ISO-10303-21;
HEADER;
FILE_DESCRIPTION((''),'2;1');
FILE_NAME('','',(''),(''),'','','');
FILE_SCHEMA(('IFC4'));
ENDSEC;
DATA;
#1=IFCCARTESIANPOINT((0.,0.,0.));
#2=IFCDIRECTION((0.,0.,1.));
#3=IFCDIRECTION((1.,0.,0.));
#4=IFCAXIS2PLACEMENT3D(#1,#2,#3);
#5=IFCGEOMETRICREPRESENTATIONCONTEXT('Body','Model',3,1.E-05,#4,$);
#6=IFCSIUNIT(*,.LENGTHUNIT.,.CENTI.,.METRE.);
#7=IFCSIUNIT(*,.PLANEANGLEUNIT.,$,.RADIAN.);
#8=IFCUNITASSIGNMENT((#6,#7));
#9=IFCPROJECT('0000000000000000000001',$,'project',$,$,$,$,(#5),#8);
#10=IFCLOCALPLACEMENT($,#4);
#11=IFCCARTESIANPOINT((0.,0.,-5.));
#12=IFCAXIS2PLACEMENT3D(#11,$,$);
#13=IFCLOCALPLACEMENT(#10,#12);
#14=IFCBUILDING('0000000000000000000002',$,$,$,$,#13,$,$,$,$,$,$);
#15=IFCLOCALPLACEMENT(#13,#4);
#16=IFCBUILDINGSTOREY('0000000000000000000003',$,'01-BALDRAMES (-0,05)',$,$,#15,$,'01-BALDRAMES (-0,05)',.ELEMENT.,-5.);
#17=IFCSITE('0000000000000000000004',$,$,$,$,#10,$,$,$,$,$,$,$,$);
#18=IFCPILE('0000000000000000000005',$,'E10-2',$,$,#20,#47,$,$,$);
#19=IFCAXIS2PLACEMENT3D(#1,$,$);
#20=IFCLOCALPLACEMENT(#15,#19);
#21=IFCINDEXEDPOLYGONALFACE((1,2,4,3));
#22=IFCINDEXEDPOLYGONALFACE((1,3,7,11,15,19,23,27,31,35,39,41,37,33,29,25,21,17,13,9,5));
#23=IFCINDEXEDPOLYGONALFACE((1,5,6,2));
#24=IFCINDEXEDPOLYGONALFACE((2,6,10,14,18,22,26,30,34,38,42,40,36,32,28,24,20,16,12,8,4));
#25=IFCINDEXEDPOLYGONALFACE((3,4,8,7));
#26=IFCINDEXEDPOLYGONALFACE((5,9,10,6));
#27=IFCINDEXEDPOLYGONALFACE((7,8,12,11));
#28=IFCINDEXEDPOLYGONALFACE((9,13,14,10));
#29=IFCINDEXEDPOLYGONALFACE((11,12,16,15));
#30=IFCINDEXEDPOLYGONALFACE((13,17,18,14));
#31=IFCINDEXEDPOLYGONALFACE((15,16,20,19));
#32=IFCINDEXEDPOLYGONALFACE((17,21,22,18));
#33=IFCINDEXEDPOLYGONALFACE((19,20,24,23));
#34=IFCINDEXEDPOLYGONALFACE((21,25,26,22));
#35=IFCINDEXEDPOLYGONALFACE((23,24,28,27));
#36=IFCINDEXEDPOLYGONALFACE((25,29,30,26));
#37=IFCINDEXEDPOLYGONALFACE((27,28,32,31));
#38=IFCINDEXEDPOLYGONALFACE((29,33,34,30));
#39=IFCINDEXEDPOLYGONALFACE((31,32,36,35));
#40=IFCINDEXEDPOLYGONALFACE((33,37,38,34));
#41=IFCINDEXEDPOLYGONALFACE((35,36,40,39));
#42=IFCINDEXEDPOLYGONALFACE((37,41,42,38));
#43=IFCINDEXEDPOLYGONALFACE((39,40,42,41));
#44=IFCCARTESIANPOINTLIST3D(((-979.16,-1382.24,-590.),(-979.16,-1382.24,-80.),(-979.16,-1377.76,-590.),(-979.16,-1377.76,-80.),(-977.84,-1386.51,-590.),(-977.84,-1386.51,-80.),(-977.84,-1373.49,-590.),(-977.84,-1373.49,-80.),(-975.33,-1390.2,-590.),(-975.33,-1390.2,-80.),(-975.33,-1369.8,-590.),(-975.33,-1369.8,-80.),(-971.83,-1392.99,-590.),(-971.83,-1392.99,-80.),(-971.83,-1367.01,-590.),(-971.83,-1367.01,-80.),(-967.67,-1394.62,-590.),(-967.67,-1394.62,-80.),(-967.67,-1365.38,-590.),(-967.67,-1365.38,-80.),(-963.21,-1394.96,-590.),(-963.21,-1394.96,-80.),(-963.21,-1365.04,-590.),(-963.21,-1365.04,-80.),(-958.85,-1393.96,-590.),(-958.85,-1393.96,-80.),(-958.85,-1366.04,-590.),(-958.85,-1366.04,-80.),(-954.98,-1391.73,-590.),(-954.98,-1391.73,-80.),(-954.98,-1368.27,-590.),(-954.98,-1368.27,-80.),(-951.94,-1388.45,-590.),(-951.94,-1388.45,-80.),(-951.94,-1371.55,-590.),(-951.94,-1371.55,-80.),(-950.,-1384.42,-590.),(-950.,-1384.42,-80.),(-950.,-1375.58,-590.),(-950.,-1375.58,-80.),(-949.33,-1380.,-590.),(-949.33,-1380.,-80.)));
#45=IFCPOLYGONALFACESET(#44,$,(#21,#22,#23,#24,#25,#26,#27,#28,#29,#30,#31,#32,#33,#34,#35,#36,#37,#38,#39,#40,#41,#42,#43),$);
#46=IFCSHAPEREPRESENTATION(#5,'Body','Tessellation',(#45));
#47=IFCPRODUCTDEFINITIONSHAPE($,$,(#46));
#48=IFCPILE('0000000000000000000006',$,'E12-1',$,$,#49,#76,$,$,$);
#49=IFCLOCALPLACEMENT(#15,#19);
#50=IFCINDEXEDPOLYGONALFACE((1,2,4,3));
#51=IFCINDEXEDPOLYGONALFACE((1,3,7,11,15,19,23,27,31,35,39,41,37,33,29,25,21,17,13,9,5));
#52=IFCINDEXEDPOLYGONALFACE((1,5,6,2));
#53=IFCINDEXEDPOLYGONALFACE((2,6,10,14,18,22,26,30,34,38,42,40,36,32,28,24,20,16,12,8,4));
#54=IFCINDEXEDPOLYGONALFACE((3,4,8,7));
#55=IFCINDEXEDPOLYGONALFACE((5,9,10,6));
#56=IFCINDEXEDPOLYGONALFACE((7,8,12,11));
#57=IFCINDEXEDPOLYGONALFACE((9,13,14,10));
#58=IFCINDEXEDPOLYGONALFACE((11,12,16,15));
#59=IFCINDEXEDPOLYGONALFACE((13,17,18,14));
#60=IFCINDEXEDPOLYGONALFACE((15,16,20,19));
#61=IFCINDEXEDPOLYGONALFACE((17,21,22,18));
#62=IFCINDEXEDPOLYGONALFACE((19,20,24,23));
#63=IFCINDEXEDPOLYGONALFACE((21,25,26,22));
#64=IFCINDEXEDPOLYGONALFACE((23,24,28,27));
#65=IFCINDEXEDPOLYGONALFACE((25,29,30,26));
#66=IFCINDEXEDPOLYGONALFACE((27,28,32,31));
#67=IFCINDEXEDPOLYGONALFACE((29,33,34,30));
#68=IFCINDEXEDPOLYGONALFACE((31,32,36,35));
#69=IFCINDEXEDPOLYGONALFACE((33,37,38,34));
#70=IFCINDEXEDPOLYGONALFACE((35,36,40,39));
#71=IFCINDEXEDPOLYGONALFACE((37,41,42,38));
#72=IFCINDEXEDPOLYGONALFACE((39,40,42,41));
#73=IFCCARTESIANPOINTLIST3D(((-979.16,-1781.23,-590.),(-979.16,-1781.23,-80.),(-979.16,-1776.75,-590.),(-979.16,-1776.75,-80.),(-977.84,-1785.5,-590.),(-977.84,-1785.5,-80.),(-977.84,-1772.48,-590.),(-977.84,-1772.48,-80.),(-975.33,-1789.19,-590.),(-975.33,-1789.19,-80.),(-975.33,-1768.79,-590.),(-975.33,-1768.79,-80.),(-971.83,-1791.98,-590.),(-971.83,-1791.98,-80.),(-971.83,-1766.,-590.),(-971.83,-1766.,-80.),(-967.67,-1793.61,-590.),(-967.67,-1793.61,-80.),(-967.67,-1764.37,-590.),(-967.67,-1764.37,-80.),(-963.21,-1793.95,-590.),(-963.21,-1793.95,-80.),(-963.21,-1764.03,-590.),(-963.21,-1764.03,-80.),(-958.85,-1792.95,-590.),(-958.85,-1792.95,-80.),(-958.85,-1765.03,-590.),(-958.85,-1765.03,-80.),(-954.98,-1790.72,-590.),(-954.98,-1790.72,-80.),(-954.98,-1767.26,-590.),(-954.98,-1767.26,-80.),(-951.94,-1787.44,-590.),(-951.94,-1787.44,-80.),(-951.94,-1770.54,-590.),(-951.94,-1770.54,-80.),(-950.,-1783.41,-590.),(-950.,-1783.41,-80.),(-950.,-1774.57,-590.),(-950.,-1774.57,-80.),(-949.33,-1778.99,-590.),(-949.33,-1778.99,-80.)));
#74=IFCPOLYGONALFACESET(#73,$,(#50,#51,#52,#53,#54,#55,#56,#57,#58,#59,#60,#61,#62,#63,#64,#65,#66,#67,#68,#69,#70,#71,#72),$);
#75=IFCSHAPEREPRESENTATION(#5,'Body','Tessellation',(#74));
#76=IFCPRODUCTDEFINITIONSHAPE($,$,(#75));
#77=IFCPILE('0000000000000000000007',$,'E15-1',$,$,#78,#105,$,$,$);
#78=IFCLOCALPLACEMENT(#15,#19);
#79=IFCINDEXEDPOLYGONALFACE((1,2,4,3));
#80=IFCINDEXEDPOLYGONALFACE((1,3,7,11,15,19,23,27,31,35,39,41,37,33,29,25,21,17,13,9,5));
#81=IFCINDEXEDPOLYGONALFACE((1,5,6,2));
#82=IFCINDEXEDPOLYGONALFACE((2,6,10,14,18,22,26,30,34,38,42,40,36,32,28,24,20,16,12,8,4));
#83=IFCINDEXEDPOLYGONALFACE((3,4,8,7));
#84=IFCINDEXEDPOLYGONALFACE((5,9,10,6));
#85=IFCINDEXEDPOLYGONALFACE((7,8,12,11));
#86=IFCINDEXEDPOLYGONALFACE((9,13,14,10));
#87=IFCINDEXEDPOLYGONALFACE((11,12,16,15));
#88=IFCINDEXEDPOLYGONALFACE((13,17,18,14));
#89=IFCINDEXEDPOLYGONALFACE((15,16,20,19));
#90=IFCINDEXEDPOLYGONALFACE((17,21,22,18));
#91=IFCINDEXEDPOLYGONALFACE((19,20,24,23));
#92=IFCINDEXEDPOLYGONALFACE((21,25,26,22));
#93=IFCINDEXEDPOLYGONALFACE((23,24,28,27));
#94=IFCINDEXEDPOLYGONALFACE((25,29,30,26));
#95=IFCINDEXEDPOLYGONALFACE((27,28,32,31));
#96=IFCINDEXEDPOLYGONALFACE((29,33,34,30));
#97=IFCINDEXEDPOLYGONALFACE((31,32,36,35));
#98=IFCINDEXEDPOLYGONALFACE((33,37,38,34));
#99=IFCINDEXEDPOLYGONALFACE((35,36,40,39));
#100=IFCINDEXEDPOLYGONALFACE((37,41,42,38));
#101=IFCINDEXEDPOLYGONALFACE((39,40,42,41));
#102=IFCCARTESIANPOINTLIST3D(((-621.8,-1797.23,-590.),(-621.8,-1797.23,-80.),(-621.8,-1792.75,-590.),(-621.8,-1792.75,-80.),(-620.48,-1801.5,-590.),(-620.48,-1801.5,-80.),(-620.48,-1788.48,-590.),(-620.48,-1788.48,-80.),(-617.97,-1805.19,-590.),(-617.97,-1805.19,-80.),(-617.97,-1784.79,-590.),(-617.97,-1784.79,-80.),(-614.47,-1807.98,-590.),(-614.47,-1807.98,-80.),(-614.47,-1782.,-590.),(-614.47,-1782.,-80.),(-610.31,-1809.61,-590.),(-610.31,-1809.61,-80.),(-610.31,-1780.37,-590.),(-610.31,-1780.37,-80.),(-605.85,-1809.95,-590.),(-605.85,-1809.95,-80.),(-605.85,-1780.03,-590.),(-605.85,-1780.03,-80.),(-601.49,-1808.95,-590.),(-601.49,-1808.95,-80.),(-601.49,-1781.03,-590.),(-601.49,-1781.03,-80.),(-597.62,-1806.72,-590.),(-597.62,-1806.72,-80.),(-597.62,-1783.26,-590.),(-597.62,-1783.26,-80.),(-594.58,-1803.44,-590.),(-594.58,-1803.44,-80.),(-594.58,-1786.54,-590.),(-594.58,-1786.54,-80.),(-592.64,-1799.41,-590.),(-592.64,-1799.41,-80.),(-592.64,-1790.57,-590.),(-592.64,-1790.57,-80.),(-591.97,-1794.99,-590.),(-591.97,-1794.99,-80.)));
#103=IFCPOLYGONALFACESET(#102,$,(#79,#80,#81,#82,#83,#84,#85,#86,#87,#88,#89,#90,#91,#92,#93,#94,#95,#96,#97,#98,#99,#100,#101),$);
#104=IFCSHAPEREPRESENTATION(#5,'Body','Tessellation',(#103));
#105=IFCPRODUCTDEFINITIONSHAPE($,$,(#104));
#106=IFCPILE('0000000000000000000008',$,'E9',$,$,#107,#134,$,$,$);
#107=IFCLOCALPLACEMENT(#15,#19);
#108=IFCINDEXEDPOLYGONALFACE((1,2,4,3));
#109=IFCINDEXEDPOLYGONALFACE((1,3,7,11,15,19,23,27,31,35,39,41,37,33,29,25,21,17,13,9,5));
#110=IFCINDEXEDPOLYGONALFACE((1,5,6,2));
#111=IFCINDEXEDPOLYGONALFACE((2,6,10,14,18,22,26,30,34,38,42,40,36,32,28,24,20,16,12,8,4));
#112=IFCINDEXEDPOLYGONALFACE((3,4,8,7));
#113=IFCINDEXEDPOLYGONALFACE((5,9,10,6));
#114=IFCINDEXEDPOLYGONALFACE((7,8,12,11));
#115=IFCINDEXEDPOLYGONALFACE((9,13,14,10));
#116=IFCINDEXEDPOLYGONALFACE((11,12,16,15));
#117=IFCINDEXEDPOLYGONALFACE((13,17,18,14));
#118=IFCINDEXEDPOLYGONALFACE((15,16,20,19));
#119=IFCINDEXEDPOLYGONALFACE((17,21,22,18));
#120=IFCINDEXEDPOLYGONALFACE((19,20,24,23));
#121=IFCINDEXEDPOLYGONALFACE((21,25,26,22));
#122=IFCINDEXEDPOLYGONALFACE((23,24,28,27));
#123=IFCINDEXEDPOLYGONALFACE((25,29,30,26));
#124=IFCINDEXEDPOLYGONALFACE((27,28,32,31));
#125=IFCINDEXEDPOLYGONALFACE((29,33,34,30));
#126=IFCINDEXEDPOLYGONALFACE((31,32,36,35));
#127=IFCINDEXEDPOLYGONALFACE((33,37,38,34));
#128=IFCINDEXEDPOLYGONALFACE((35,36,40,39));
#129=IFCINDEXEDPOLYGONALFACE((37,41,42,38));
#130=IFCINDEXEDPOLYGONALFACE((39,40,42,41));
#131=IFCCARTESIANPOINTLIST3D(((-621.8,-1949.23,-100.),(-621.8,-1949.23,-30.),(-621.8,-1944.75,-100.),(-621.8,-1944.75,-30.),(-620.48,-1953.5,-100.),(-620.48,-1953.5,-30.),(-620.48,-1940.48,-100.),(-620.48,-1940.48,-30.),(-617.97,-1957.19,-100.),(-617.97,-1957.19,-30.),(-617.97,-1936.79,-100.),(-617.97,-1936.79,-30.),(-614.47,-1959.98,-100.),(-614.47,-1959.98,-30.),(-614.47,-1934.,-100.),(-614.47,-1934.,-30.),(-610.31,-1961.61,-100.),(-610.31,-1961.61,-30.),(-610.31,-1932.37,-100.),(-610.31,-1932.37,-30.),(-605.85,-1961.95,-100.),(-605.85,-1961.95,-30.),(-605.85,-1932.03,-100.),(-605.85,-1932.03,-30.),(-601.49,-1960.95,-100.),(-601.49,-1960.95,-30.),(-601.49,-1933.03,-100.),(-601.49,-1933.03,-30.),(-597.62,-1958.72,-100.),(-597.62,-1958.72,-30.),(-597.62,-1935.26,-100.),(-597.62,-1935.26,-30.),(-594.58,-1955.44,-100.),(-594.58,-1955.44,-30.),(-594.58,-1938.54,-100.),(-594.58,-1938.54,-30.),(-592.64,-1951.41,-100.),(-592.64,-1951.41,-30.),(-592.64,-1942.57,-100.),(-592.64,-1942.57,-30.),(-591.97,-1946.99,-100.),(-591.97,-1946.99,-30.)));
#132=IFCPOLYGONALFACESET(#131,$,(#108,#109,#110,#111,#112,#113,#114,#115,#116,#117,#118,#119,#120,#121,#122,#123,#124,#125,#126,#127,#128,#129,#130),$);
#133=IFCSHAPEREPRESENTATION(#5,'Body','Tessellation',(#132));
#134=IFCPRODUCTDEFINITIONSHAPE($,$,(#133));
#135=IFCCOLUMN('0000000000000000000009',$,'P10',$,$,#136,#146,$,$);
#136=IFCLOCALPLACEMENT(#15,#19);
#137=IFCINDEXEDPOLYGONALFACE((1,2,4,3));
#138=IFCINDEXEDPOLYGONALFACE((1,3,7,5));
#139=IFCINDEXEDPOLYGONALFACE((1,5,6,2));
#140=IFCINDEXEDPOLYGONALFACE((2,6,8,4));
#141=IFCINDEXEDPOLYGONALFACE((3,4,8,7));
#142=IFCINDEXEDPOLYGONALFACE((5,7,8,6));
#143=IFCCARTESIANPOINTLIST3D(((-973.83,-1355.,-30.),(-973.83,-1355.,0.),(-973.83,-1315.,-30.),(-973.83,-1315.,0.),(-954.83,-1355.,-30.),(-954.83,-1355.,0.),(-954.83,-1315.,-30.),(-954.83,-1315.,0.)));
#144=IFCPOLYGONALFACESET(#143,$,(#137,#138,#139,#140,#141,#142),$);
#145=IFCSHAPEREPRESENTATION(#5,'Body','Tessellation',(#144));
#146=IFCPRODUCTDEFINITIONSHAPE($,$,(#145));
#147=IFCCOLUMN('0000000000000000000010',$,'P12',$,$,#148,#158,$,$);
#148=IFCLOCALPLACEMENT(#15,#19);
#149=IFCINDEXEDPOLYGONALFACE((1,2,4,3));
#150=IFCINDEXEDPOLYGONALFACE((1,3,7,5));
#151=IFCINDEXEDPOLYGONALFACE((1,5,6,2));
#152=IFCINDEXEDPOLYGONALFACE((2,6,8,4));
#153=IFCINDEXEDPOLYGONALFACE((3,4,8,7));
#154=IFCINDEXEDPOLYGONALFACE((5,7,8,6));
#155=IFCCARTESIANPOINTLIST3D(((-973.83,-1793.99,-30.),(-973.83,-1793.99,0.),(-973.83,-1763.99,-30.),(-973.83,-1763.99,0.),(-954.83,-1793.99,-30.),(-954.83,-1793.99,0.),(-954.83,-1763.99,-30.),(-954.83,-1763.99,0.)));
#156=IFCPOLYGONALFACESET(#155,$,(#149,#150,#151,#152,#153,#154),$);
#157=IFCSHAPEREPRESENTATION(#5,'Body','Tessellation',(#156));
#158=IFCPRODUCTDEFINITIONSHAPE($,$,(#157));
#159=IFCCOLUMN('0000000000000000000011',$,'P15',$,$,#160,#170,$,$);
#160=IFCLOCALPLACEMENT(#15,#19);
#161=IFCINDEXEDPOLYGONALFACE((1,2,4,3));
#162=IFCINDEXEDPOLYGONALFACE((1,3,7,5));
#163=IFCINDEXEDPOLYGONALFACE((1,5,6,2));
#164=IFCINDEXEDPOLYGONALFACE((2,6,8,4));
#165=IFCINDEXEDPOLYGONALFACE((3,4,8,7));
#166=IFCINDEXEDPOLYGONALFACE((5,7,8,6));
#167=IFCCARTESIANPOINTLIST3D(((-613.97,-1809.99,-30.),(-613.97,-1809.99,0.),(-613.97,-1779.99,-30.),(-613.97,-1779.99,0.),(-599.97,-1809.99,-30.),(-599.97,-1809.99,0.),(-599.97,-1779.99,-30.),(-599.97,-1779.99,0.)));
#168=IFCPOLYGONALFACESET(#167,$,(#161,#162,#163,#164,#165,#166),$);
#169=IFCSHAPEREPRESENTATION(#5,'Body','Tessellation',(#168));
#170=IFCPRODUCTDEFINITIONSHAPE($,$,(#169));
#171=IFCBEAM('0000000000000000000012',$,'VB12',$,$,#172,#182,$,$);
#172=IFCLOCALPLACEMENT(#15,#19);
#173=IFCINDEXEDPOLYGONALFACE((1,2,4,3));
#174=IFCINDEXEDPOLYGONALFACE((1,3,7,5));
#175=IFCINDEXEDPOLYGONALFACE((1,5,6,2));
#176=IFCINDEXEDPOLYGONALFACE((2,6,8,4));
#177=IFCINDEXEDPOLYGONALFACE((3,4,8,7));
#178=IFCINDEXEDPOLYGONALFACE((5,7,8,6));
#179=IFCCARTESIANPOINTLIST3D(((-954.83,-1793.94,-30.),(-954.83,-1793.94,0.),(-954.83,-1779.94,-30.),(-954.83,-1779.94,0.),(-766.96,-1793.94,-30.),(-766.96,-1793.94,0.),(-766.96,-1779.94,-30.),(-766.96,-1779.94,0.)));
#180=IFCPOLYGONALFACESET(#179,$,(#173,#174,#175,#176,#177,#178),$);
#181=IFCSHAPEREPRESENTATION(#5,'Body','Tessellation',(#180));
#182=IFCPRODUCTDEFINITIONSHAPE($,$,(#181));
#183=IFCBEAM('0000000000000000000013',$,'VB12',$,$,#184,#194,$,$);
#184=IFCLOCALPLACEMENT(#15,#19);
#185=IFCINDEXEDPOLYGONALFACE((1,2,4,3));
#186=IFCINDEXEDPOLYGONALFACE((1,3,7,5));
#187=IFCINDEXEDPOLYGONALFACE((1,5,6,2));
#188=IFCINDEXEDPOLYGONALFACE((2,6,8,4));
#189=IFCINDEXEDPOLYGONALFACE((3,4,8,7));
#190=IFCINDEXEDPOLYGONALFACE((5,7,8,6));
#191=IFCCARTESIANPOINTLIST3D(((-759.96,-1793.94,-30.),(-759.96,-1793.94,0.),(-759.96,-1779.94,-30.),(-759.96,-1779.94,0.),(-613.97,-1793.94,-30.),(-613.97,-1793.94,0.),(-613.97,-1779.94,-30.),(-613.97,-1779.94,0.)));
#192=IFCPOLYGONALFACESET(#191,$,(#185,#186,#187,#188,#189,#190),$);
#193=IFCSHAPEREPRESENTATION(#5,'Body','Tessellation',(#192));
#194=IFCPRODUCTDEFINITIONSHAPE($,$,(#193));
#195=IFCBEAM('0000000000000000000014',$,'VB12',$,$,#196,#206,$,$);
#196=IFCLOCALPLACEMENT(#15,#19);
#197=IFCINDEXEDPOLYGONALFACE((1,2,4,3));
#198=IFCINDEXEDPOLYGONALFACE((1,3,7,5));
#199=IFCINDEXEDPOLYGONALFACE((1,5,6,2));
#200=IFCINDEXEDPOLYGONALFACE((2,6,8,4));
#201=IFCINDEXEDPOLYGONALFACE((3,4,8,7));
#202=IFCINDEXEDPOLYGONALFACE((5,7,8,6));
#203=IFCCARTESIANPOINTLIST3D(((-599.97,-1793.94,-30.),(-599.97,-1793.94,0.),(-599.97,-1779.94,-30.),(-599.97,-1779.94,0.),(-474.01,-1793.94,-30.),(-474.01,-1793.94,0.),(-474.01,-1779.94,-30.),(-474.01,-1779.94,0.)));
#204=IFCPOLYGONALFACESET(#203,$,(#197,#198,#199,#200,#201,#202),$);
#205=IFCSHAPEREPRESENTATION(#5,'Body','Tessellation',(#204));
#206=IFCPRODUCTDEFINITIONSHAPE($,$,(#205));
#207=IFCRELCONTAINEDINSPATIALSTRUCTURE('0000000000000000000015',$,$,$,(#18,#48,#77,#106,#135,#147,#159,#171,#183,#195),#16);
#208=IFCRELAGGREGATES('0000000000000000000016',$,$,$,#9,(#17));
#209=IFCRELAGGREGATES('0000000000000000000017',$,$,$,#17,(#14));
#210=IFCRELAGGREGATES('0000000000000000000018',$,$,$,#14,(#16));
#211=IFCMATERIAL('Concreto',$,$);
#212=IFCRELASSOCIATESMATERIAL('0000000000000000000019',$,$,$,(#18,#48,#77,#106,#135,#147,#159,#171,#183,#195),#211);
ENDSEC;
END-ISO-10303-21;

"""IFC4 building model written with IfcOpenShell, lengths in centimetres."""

from ifc_helpers import new_model, si_unit, frame, origin_with_axes, origin_2d_with_axis, place, context, project, spatial, rectangle, circle, extrude, material, element, save


model = new_model("IFC4")

# Units and contexts
model_context = context("Model", 3, precision=1e-05, world=origin_with_axes(), identifier="Body")
ifc_project = project(units=[si_unit("LENGTHUNIT", "METRE", prefix="CENTI"), si_unit("PLANEANGLEUNIT", "RADIAN")], contexts=[model_context])

# Site, building, storey
site_placement = place(None, origin_with_axes())
site = spatial("IfcSite", under=ifc_project, at=site_placement)
building_placement = place(site_placement, frame((0.0, 0.0, -5.0)))
building = spatial("IfcBuilding", under=site, at=building_placement)
storey_placement = place(building_placement, origin_with_axes())
storey = spatial("IfcBuildingStorey", under=building, at=storey_placement, Name="01-BALDRAMES (-0,05)", LongName="01-BALDRAMES (-0,05)", CompositionType="ELEMENT", Elevation=-5.0)

# Piles
ifc_material = material(Name="Concreto")
for number, where, z_axis, x_axis, name in (
    (1, (-964.33, -1380.0, -80.0), (0.0, 0.0, 1.0), (1.0, 0.0, 0.0), "E10-2"),
    (2, (-964.33, -1778.99, -80.0), (0.0, 0.0, 1.0), (1.0, 0.0, 0.0), "E12-1"),
    (3, (-606.97, -1794.99, -80.0), (0.0, 0.0, 1.0), (1.0, 0.0, 0.0), "E15-1"),
):
    element("IfcPile", number, at=place(storey_placement, frame(where, z_axis=z_axis, x_axis=x_axis)), inside=storey, material=ifc_material, Name=name, context=model_context, shape_type="SweptSolid", body=[
        extrude(circle(Radius=15.0, at=origin_2d_with_axis()), frame((0.0, 0.0, -510.0), z_axis=(0.0, 0.0, 1.0), x_axis=(1.0, 0.0, 0.0)), (0.0, 0.0, 1.0), 510.0),
    ])
pile_placement = place(storey_placement, frame((-606.97, -1946.99, -30.0), z_axis=(0.0, 0.0, 1.0), x_axis=(1.0, 0.0, 0.0)))
element("IfcPile", 4, at=pile_placement, inside=storey, material=ifc_material, Name="E9", context=model_context, shape_type="SolidModel", body=[
    extrude(circle(Radius=15.0, at=origin_2d_with_axis()), frame((0.0, 0.0, -70.0), z_axis=(0.0, 0.0, 1.0), x_axis=(1.0, 0.0, 0.0)), (0.0, 0.0, 1.0), 70.0),
])

# Columns
column_1_placement = place(storey_placement, frame((-964.33, -1335.0, 0.0), z_axis=(0.0, 0.0, 1.0), x_axis=(1.0, 0.0, 0.0)))
element("IfcColumn", 5, at=column_1_placement, inside=storey, material=ifc_material, Name="P10", context=model_context, shape_type="SolidModel", body=[
    extrude(rectangle(XDim=19.0, YDim=40.0, at=origin_2d_with_axis()), origin_with_axes(), (0.0, 0.0, -1.0), 30.0),
])
column_2_placement = place(storey_placement, frame((-964.33, -1778.99, 0.0), z_axis=(0.0, 0.0, 1.0), x_axis=(1.0, 0.0, 0.0)))
element("IfcColumn", 6, at=column_2_placement, inside=storey, material=ifc_material, Name="P12", context=model_context, shape_type="SolidModel", body=[
    extrude(rectangle(XDim=19.0, YDim=30.0, at=origin_2d_with_axis()), origin_with_axes(), (0.0, 0.0, -1.0), 30.0),
])
column_3_placement = place(storey_placement, frame((-606.97, -1794.99, 0.0), z_axis=(0.0, 0.0, 1.0), x_axis=(1.0, 0.0, 0.0)))
element("IfcColumn", 7, at=column_3_placement, inside=storey, material=ifc_material, Name="P15", context=model_context, shape_type="SolidModel", body=[
    extrude(rectangle(XDim=14.0, YDim=30.0, at=origin_2d_with_axis()), origin_with_axes(), (0.0, 0.0, -1.0), 30.0),
])

# Beams
beam_1_placement = place(storey_placement, frame((-860.89, -1786.94, 0.0), z_axis=(0.0, 0.0, 1.0), x_axis=(1.0, 0.0, 0.0)))
element("IfcBeam", 8, at=beam_1_placement, inside=storey, material=ifc_material, Name="VB12", context=model_context, shape_type="SolidModel", body=[
    extrude(rectangle(XDim=14.0, YDim=30.0, at=origin_2d_with_axis()), frame((-93.94, 0.0, -15.0), z_axis=(1.0, 0.0, 0.0), x_axis=(0.0, -1.0, 0.0)), (0.0, 0.0, 1.0), 187.87),
])
beam_2_placement = place(storey_placement, frame((-686.97, -1786.94, 0.0), z_axis=(0.0, 0.0, 1.0), x_axis=(1.0, 0.0, 0.0)))
element("IfcBeam", 9, at=beam_2_placement, inside=storey, material=ifc_material, Name="VB12", context=model_context, shape_type="SolidModel", body=[
    extrude(rectangle(XDim=14.0, YDim=30.0, at=origin_2d_with_axis()), frame((-73.0, 0.0, -15.0), z_axis=(1.0, 0.0, 0.0), x_axis=(0.0, -1.0, 0.0)), (0.0, 0.0, 1.0), 145.99),
])
beam_3_placement = place(storey_placement, frame((-536.99, -1786.94, 0.0), z_axis=(0.0, 0.0, 1.0), x_axis=(1.0, 0.0, 0.0)))
element("IfcBeam", 10, at=beam_3_placement, inside=storey, material=ifc_material, Name="VB12", context=model_context, shape_type="SolidModel", body=[
    extrude(rectangle(XDim=14.0, YDim=30.0, at=origin_2d_with_axis()), frame((-62.98, 0.0, -15.0), z_axis=(1.0, 0.0, 0.0), x_axis=(0.0, -1.0, 0.0)), (0.0, 0.0, 1.0), 125.96),
])

save(model, "model.ifc")
